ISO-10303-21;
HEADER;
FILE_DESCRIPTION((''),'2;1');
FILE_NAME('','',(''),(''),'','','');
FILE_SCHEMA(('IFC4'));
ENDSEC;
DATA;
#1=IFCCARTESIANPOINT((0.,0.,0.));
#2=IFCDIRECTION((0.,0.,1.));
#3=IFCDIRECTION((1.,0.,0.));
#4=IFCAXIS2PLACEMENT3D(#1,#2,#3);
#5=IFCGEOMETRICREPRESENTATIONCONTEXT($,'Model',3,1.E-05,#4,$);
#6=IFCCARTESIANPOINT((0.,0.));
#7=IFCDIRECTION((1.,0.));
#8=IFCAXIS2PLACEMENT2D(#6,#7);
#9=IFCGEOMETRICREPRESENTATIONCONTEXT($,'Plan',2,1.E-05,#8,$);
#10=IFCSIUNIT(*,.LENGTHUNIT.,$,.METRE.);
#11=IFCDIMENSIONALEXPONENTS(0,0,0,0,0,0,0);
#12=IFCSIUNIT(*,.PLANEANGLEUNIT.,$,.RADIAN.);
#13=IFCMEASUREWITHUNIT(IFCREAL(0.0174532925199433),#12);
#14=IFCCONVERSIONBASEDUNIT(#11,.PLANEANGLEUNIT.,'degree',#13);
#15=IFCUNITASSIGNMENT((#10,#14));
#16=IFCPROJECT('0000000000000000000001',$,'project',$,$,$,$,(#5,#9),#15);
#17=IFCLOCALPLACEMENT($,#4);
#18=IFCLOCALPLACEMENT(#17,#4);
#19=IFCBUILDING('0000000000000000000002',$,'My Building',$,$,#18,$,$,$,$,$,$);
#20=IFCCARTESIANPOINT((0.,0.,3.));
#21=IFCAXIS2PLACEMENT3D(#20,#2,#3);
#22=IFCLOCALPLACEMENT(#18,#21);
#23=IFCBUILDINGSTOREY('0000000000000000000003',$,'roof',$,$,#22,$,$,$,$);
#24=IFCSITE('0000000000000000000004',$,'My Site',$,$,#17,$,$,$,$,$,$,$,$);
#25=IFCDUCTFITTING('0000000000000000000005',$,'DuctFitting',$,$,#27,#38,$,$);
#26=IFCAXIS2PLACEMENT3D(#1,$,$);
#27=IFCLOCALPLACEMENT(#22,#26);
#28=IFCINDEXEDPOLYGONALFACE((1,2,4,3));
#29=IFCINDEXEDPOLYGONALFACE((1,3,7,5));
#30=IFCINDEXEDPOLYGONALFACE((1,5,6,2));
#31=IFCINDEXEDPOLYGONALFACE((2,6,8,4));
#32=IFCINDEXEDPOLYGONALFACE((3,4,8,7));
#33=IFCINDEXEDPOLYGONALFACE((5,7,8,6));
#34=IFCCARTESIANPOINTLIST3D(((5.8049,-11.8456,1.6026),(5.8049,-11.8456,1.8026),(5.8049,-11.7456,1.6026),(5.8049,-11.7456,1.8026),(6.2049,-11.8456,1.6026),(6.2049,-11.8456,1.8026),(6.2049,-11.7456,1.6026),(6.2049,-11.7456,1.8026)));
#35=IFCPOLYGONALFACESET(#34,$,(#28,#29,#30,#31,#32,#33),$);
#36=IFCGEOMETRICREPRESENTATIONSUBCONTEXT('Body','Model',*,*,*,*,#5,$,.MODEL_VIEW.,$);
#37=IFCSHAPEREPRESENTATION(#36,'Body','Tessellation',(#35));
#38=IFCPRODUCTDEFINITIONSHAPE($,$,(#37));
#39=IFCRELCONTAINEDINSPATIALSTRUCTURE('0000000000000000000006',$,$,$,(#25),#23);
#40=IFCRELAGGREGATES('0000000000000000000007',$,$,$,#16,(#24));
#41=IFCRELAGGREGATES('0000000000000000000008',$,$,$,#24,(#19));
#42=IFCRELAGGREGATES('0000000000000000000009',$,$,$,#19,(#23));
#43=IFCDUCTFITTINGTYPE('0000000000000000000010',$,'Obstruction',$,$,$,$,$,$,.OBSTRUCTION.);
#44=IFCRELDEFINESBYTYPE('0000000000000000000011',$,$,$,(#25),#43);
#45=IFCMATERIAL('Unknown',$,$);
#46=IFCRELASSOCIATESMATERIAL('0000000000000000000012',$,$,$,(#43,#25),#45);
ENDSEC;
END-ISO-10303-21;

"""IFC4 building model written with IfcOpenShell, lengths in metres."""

from ifc_helpers import new_model, entity, si_unit, converted_unit, frame, origin_with_axes, origin_2d_with_axis, place, context, subcontext, project, spatial, rectangle, extrude, material, material_profile, profile_set, profile_usage, type_object, element, save


model = new_model("IFC4")

# Units and contexts
model_context = context("Model", 3, precision=1e-05, world=origin_with_axes())
plan_context = context("Plan", 2, precision=1e-05, world=origin_2d_with_axis())
body_context_1 = subcontext(model_context, "Body", "Model", "MODEL_VIEW")
ifc_project = project(units=[si_unit("LENGTHUNIT", "METRE"), converted_unit("PLANEANGLEUNIT", "degree", entity("IfcReal", 0.0174532925199433), si_unit("PLANEANGLEUNIT", "RADIAN"), dimensions=[0, 0, 0, 0, 0, 0, 0])], contexts=[model_context, plan_context])

# Site, building, storey
site_placement = place(None, origin_with_axes())
site = spatial("IfcSite", under=ifc_project, at=site_placement, Name="My Site")
building_placement = place(site_placement, origin_with_axes())
building = spatial("IfcBuilding", under=site, at=building_placement, Name="My Building")
storey_placement = place(building_placement, frame((0.0, 0.0, 3.0), z_axis=(0.0, 0.0, 1.0), x_axis=(1.0, 0.0, 0.0)))
storey = spatial("IfcBuildingStorey", under=building, at=storey_placement, Name="roof")

# Shared definitions
ifc_material = material(Name="Unknown")

# Duct fitting
ifc_material_profile_1 = material_profile(ifc_material, rectangle(XDim=0.4, YDim=0.2))
ifc_profile_set_1 = profile_set([ifc_material_profile_1])
ifc_profile_usage_1 = profile_usage(ifc_profile_set_1, cardinal=5)
duct_fitting_type = type_object("IfcDuctFittingType", Name="Obstruction", PredefinedType="OBSTRUCTION", material=ifc_profile_set_1)
duct_fitting_placement = place(storey_placement, frame((6.0049, -11.7456, 1.7026), z_axis=(0.0, -1.0, 0.0), x_axis=(-1.0, 0.0, 0.0)))
element("IfcDuctFitting", 1, at=duct_fitting_placement, inside=storey, type_object=duct_fitting_type, material=ifc_profile_usage_1, Name="DuctFitting", context=body_context_1, shape_type="SweptSolid", body=[
    extrude(rectangle(XDim=0.4, YDim=0.2), origin_with_axes(), (0.0, 0.0, 1.0), 0.1),
])

save(model, "model.ifc")
